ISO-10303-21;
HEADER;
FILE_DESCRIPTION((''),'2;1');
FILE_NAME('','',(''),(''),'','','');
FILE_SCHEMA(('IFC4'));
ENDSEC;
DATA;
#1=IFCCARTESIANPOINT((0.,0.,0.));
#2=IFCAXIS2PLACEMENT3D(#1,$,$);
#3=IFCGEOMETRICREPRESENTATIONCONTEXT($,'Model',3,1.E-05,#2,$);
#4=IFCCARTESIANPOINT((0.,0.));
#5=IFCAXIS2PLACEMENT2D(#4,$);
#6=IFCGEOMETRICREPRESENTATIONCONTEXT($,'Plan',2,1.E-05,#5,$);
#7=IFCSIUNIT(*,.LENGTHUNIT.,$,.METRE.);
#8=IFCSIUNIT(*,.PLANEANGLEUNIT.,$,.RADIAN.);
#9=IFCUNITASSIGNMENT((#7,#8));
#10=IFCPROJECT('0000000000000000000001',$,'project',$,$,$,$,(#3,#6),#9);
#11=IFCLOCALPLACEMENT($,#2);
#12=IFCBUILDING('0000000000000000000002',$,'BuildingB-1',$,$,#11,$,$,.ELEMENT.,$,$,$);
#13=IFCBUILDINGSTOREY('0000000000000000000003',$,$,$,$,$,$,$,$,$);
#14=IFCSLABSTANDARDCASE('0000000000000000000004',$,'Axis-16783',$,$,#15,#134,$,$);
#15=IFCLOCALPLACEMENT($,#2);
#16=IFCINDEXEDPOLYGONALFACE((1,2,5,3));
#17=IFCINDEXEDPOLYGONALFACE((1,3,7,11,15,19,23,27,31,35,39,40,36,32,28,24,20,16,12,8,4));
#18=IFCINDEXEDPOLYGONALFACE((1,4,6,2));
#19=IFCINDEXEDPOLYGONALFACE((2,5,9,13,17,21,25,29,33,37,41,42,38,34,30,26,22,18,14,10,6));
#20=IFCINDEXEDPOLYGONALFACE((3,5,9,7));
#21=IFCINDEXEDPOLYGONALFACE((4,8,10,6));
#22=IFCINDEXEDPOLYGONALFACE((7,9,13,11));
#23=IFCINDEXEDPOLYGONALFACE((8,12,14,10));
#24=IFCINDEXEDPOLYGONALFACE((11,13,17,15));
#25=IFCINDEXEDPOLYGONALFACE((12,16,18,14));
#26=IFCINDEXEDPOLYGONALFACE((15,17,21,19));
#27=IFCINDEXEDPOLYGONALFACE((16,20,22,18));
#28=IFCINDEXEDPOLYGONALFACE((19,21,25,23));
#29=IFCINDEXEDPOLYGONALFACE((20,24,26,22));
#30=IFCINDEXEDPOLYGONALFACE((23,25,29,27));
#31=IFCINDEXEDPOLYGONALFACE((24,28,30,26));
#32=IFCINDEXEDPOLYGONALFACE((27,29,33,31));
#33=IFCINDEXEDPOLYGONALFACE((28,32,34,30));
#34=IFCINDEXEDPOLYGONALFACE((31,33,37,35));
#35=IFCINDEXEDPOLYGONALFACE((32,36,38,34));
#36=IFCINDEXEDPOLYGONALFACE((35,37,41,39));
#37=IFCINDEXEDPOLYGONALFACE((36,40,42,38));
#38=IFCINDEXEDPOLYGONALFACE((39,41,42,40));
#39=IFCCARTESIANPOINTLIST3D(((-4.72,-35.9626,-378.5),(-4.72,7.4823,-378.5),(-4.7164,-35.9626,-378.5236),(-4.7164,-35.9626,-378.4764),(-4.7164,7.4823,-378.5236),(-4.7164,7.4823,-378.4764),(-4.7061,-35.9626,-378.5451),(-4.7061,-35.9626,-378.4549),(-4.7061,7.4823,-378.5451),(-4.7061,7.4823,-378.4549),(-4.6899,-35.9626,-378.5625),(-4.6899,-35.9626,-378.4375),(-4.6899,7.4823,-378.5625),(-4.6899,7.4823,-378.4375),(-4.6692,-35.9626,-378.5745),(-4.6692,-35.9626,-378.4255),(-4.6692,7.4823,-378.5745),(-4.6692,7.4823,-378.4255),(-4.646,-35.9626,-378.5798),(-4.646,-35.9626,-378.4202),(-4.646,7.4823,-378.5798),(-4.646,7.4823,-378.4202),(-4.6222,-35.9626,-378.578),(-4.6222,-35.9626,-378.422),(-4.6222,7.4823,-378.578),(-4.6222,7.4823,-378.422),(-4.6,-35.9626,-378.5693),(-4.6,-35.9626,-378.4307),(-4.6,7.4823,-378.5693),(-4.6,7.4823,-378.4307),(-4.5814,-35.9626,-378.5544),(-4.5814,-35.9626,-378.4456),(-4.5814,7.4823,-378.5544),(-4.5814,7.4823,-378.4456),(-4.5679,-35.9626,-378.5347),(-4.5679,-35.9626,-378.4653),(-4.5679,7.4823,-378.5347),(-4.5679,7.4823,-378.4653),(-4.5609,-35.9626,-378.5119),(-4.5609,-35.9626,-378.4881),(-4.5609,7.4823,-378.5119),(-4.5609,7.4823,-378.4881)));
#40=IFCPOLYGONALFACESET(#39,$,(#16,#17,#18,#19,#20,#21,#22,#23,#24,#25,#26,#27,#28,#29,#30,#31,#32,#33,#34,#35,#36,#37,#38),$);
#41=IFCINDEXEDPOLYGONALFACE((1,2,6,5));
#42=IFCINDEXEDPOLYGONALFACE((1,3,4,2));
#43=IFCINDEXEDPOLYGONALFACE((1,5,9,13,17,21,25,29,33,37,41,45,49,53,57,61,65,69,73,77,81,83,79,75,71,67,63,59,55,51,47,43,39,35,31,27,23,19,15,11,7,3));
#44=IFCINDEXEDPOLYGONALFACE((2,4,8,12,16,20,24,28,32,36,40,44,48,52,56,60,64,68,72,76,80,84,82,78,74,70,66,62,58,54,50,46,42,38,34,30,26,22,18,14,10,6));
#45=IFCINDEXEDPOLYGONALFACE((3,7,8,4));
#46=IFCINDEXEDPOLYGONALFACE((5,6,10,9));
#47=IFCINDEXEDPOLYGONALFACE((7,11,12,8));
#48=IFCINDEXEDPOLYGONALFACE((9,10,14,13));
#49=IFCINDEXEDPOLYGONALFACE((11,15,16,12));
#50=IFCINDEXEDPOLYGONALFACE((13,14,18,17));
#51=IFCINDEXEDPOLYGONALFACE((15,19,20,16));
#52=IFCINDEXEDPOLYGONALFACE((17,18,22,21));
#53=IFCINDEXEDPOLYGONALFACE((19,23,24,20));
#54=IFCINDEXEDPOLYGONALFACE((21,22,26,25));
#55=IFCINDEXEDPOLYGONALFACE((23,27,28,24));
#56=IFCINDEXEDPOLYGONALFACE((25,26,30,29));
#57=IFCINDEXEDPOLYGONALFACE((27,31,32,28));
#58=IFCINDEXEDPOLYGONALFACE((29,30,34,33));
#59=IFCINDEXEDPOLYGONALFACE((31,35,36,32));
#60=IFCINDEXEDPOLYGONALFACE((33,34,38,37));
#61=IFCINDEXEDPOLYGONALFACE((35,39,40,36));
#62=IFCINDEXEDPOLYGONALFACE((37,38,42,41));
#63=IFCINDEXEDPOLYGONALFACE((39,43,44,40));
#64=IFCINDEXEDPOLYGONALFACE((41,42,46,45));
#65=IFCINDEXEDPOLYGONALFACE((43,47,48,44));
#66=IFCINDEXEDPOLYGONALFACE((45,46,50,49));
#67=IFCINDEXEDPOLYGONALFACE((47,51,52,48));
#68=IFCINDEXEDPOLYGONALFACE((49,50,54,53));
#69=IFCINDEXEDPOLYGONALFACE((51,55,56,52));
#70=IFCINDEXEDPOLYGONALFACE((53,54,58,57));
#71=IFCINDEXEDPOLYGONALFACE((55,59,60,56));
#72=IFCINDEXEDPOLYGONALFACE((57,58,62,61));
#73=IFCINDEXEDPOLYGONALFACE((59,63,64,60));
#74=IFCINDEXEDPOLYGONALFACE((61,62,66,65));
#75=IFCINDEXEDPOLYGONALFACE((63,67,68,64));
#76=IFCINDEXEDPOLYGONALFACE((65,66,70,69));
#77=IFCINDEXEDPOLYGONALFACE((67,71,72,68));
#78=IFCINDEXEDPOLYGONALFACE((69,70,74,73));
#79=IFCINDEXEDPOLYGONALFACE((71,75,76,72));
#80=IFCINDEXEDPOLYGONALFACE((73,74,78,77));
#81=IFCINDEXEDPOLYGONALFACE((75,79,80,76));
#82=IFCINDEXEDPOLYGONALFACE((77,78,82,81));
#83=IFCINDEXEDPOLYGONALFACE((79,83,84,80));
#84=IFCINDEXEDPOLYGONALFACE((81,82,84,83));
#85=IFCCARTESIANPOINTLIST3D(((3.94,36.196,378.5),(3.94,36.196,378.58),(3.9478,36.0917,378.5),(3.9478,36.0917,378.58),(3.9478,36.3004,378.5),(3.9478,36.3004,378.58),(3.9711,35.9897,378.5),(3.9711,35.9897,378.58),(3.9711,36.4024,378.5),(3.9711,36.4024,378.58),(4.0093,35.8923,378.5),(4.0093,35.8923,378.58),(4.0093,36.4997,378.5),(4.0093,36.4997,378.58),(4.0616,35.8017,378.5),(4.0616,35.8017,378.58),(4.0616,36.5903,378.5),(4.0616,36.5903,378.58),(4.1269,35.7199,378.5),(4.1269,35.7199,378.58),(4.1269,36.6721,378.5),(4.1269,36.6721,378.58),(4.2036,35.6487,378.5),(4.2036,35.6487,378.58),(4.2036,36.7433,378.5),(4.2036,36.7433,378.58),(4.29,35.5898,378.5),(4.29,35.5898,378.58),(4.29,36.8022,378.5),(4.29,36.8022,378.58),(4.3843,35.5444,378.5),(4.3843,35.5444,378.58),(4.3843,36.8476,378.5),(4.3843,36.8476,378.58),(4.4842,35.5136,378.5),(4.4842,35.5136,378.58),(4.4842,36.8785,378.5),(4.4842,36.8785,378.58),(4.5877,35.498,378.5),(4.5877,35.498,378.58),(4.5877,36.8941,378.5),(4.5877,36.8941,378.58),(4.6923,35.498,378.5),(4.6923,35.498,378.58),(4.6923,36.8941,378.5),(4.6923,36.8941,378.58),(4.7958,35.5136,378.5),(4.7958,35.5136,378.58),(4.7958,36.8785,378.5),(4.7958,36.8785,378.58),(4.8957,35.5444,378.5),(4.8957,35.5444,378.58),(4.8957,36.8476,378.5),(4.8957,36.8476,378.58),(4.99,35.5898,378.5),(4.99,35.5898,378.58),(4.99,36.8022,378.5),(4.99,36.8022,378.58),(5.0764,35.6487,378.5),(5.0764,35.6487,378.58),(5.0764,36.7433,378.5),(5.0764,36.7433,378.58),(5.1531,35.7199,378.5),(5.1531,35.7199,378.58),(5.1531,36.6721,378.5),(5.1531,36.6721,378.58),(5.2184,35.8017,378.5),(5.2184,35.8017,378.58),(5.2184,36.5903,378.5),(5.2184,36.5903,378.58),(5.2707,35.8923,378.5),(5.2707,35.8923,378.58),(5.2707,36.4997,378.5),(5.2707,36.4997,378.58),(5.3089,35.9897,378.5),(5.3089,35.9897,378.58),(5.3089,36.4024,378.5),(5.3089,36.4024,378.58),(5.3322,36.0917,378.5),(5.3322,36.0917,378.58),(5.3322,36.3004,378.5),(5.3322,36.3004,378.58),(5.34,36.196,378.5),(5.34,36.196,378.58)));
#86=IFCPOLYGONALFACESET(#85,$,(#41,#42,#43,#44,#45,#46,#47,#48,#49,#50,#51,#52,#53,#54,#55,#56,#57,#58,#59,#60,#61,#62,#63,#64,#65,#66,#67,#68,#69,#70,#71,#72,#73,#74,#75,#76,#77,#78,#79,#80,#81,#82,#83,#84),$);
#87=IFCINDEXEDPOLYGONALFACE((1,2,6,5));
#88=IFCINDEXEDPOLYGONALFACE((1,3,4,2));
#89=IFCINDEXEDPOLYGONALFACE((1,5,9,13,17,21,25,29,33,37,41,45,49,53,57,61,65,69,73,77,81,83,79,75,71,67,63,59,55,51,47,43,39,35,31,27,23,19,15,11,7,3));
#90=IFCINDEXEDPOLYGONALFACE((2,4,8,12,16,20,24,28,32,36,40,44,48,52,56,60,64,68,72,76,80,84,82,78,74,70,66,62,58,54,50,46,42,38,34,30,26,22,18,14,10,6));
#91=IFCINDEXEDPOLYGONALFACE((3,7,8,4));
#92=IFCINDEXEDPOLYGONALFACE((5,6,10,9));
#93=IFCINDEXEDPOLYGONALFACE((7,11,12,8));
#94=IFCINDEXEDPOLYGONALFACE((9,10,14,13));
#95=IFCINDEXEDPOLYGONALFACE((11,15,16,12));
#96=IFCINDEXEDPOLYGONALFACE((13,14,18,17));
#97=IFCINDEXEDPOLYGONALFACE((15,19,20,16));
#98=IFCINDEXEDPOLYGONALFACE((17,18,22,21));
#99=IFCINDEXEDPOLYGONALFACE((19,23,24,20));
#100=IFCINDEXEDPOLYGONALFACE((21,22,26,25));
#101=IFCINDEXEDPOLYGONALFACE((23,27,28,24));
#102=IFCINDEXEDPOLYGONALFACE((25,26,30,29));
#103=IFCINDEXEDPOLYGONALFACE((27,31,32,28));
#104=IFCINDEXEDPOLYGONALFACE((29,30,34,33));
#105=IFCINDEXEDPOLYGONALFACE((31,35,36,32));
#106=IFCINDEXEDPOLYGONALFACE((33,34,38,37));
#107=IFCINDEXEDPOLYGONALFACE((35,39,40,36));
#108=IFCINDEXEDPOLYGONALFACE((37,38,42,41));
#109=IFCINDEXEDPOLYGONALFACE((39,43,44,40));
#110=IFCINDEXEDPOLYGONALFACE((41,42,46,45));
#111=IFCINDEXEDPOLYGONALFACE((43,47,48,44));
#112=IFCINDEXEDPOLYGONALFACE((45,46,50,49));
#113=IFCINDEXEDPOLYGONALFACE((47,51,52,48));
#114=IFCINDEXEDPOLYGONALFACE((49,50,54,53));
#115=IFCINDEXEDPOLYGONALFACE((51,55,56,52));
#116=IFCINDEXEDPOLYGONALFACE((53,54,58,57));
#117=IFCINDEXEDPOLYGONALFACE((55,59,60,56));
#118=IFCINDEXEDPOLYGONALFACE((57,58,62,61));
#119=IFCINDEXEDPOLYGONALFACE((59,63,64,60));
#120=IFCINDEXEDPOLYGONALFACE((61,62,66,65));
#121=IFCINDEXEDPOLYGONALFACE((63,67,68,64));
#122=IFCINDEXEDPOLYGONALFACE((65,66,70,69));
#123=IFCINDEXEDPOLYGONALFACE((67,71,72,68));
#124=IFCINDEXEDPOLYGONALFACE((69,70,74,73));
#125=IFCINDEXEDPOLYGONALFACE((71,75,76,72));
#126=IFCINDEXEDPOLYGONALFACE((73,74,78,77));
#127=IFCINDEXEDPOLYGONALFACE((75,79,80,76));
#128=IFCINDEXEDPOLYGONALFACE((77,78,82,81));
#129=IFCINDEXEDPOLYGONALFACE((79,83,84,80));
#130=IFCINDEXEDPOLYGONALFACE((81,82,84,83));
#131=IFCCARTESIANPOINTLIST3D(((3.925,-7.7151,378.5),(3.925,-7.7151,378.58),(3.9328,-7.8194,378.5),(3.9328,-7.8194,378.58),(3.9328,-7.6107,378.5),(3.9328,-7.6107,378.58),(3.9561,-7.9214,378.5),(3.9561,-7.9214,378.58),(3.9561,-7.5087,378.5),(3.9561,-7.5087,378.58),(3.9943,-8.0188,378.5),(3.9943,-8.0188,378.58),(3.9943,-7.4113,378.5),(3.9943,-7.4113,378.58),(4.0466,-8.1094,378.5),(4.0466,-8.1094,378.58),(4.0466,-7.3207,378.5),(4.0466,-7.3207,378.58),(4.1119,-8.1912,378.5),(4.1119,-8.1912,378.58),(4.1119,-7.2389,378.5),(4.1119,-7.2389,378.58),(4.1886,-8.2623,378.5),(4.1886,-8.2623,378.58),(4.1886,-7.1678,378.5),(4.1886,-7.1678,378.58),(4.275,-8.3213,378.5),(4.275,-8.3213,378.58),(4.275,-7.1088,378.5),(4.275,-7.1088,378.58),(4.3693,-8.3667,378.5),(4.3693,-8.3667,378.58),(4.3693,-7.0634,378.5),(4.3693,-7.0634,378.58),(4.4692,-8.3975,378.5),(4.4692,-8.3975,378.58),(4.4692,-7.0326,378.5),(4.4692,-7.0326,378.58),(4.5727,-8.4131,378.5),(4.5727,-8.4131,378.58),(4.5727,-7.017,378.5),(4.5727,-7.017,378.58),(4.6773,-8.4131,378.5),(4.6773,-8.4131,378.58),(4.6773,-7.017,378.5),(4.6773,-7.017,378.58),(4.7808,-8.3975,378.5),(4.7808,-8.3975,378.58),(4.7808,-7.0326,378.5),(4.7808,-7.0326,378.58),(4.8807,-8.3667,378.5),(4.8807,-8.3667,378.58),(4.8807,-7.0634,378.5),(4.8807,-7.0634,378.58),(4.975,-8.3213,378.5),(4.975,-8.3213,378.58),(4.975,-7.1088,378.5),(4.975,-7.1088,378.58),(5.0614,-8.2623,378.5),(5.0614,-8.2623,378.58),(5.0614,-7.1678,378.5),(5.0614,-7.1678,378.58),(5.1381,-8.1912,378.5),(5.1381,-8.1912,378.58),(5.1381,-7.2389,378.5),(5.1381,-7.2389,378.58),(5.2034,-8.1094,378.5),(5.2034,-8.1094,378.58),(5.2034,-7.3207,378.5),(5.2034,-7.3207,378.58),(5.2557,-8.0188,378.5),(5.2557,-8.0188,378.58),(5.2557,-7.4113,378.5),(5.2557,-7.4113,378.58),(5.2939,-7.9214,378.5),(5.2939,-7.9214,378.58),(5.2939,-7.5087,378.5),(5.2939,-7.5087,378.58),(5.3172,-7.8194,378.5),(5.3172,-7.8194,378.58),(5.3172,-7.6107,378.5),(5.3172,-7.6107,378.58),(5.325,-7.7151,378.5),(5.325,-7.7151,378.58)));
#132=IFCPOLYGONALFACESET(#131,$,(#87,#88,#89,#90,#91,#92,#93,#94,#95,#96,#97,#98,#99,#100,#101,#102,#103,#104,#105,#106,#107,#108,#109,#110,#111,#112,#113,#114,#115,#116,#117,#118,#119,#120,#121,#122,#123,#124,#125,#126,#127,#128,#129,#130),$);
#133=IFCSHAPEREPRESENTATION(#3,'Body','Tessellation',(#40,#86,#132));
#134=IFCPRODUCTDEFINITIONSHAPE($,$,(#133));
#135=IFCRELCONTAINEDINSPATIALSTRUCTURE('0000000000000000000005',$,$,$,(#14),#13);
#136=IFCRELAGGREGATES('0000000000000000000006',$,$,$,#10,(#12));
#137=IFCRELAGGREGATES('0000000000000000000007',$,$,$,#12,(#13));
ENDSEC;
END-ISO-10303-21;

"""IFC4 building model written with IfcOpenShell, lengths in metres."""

from ifc_helpers import new_model, entity, si_unit, frame, origin, origin_2d, place, context, project, spatial, circle, extrude, element, save


model = new_model("IFC4")

# Units and contexts
model_context = context("Model", 3, precision=1e-05, world=origin())
plan_context = context("Plan", 2, precision=1e-05, world=origin_2d())
ifc_project = project(units=[si_unit("LENGTHUNIT", "METRE"), si_unit("PLANEANGLEUNIT", "RADIAN")], contexts=[model_context, plan_context])

# Building, storey
building_placement = place(None, origin())
building = spatial("IfcBuilding", under=ifc_project, at=building_placement, Name="BuildingB-1", CompositionType="ELEMENT")
storey = spatial("IfcBuildingStorey", under=building)

# Slab
element("IfcSlabStandardCase", 1, inside=storey, Name="Axis-16783", context=model_context, shape_type="AdvancedSweptSolid", body=[
    entity("IfcSurfaceCurveSweptAreaSolid", entity("IfcCircleProfileDef", "AREA", None, None, 0.08), None, entity("IfcPolyline", [entity("IfcCartesianPoint", [4.64, 35.9626, 378.5]), entity("IfcCartesianPoint", [4.64, -7.4823, 378.5])]), None, None, entity("IfcPlane", entity("IfcAxis2Placement3D", entity("IfcCartesianPoint", [4.64, 35.9626, 378.5]), entity("IfcDirection", [0.0, 0.0, 1.0]), entity("IfcDirection", [1.0, 0.0, 0.0])))),
    extrude(circle(Radius=0.7), frame((4.64, 36.196, 378.5)), (0.0, 0.0, 1.0), 0.08),
    extrude(circle(Radius=0.7), frame((4.625, -7.7151, 378.5)), (0.0, 0.0, 1.0), 0.08),
])

save(model, "model.ifc")
